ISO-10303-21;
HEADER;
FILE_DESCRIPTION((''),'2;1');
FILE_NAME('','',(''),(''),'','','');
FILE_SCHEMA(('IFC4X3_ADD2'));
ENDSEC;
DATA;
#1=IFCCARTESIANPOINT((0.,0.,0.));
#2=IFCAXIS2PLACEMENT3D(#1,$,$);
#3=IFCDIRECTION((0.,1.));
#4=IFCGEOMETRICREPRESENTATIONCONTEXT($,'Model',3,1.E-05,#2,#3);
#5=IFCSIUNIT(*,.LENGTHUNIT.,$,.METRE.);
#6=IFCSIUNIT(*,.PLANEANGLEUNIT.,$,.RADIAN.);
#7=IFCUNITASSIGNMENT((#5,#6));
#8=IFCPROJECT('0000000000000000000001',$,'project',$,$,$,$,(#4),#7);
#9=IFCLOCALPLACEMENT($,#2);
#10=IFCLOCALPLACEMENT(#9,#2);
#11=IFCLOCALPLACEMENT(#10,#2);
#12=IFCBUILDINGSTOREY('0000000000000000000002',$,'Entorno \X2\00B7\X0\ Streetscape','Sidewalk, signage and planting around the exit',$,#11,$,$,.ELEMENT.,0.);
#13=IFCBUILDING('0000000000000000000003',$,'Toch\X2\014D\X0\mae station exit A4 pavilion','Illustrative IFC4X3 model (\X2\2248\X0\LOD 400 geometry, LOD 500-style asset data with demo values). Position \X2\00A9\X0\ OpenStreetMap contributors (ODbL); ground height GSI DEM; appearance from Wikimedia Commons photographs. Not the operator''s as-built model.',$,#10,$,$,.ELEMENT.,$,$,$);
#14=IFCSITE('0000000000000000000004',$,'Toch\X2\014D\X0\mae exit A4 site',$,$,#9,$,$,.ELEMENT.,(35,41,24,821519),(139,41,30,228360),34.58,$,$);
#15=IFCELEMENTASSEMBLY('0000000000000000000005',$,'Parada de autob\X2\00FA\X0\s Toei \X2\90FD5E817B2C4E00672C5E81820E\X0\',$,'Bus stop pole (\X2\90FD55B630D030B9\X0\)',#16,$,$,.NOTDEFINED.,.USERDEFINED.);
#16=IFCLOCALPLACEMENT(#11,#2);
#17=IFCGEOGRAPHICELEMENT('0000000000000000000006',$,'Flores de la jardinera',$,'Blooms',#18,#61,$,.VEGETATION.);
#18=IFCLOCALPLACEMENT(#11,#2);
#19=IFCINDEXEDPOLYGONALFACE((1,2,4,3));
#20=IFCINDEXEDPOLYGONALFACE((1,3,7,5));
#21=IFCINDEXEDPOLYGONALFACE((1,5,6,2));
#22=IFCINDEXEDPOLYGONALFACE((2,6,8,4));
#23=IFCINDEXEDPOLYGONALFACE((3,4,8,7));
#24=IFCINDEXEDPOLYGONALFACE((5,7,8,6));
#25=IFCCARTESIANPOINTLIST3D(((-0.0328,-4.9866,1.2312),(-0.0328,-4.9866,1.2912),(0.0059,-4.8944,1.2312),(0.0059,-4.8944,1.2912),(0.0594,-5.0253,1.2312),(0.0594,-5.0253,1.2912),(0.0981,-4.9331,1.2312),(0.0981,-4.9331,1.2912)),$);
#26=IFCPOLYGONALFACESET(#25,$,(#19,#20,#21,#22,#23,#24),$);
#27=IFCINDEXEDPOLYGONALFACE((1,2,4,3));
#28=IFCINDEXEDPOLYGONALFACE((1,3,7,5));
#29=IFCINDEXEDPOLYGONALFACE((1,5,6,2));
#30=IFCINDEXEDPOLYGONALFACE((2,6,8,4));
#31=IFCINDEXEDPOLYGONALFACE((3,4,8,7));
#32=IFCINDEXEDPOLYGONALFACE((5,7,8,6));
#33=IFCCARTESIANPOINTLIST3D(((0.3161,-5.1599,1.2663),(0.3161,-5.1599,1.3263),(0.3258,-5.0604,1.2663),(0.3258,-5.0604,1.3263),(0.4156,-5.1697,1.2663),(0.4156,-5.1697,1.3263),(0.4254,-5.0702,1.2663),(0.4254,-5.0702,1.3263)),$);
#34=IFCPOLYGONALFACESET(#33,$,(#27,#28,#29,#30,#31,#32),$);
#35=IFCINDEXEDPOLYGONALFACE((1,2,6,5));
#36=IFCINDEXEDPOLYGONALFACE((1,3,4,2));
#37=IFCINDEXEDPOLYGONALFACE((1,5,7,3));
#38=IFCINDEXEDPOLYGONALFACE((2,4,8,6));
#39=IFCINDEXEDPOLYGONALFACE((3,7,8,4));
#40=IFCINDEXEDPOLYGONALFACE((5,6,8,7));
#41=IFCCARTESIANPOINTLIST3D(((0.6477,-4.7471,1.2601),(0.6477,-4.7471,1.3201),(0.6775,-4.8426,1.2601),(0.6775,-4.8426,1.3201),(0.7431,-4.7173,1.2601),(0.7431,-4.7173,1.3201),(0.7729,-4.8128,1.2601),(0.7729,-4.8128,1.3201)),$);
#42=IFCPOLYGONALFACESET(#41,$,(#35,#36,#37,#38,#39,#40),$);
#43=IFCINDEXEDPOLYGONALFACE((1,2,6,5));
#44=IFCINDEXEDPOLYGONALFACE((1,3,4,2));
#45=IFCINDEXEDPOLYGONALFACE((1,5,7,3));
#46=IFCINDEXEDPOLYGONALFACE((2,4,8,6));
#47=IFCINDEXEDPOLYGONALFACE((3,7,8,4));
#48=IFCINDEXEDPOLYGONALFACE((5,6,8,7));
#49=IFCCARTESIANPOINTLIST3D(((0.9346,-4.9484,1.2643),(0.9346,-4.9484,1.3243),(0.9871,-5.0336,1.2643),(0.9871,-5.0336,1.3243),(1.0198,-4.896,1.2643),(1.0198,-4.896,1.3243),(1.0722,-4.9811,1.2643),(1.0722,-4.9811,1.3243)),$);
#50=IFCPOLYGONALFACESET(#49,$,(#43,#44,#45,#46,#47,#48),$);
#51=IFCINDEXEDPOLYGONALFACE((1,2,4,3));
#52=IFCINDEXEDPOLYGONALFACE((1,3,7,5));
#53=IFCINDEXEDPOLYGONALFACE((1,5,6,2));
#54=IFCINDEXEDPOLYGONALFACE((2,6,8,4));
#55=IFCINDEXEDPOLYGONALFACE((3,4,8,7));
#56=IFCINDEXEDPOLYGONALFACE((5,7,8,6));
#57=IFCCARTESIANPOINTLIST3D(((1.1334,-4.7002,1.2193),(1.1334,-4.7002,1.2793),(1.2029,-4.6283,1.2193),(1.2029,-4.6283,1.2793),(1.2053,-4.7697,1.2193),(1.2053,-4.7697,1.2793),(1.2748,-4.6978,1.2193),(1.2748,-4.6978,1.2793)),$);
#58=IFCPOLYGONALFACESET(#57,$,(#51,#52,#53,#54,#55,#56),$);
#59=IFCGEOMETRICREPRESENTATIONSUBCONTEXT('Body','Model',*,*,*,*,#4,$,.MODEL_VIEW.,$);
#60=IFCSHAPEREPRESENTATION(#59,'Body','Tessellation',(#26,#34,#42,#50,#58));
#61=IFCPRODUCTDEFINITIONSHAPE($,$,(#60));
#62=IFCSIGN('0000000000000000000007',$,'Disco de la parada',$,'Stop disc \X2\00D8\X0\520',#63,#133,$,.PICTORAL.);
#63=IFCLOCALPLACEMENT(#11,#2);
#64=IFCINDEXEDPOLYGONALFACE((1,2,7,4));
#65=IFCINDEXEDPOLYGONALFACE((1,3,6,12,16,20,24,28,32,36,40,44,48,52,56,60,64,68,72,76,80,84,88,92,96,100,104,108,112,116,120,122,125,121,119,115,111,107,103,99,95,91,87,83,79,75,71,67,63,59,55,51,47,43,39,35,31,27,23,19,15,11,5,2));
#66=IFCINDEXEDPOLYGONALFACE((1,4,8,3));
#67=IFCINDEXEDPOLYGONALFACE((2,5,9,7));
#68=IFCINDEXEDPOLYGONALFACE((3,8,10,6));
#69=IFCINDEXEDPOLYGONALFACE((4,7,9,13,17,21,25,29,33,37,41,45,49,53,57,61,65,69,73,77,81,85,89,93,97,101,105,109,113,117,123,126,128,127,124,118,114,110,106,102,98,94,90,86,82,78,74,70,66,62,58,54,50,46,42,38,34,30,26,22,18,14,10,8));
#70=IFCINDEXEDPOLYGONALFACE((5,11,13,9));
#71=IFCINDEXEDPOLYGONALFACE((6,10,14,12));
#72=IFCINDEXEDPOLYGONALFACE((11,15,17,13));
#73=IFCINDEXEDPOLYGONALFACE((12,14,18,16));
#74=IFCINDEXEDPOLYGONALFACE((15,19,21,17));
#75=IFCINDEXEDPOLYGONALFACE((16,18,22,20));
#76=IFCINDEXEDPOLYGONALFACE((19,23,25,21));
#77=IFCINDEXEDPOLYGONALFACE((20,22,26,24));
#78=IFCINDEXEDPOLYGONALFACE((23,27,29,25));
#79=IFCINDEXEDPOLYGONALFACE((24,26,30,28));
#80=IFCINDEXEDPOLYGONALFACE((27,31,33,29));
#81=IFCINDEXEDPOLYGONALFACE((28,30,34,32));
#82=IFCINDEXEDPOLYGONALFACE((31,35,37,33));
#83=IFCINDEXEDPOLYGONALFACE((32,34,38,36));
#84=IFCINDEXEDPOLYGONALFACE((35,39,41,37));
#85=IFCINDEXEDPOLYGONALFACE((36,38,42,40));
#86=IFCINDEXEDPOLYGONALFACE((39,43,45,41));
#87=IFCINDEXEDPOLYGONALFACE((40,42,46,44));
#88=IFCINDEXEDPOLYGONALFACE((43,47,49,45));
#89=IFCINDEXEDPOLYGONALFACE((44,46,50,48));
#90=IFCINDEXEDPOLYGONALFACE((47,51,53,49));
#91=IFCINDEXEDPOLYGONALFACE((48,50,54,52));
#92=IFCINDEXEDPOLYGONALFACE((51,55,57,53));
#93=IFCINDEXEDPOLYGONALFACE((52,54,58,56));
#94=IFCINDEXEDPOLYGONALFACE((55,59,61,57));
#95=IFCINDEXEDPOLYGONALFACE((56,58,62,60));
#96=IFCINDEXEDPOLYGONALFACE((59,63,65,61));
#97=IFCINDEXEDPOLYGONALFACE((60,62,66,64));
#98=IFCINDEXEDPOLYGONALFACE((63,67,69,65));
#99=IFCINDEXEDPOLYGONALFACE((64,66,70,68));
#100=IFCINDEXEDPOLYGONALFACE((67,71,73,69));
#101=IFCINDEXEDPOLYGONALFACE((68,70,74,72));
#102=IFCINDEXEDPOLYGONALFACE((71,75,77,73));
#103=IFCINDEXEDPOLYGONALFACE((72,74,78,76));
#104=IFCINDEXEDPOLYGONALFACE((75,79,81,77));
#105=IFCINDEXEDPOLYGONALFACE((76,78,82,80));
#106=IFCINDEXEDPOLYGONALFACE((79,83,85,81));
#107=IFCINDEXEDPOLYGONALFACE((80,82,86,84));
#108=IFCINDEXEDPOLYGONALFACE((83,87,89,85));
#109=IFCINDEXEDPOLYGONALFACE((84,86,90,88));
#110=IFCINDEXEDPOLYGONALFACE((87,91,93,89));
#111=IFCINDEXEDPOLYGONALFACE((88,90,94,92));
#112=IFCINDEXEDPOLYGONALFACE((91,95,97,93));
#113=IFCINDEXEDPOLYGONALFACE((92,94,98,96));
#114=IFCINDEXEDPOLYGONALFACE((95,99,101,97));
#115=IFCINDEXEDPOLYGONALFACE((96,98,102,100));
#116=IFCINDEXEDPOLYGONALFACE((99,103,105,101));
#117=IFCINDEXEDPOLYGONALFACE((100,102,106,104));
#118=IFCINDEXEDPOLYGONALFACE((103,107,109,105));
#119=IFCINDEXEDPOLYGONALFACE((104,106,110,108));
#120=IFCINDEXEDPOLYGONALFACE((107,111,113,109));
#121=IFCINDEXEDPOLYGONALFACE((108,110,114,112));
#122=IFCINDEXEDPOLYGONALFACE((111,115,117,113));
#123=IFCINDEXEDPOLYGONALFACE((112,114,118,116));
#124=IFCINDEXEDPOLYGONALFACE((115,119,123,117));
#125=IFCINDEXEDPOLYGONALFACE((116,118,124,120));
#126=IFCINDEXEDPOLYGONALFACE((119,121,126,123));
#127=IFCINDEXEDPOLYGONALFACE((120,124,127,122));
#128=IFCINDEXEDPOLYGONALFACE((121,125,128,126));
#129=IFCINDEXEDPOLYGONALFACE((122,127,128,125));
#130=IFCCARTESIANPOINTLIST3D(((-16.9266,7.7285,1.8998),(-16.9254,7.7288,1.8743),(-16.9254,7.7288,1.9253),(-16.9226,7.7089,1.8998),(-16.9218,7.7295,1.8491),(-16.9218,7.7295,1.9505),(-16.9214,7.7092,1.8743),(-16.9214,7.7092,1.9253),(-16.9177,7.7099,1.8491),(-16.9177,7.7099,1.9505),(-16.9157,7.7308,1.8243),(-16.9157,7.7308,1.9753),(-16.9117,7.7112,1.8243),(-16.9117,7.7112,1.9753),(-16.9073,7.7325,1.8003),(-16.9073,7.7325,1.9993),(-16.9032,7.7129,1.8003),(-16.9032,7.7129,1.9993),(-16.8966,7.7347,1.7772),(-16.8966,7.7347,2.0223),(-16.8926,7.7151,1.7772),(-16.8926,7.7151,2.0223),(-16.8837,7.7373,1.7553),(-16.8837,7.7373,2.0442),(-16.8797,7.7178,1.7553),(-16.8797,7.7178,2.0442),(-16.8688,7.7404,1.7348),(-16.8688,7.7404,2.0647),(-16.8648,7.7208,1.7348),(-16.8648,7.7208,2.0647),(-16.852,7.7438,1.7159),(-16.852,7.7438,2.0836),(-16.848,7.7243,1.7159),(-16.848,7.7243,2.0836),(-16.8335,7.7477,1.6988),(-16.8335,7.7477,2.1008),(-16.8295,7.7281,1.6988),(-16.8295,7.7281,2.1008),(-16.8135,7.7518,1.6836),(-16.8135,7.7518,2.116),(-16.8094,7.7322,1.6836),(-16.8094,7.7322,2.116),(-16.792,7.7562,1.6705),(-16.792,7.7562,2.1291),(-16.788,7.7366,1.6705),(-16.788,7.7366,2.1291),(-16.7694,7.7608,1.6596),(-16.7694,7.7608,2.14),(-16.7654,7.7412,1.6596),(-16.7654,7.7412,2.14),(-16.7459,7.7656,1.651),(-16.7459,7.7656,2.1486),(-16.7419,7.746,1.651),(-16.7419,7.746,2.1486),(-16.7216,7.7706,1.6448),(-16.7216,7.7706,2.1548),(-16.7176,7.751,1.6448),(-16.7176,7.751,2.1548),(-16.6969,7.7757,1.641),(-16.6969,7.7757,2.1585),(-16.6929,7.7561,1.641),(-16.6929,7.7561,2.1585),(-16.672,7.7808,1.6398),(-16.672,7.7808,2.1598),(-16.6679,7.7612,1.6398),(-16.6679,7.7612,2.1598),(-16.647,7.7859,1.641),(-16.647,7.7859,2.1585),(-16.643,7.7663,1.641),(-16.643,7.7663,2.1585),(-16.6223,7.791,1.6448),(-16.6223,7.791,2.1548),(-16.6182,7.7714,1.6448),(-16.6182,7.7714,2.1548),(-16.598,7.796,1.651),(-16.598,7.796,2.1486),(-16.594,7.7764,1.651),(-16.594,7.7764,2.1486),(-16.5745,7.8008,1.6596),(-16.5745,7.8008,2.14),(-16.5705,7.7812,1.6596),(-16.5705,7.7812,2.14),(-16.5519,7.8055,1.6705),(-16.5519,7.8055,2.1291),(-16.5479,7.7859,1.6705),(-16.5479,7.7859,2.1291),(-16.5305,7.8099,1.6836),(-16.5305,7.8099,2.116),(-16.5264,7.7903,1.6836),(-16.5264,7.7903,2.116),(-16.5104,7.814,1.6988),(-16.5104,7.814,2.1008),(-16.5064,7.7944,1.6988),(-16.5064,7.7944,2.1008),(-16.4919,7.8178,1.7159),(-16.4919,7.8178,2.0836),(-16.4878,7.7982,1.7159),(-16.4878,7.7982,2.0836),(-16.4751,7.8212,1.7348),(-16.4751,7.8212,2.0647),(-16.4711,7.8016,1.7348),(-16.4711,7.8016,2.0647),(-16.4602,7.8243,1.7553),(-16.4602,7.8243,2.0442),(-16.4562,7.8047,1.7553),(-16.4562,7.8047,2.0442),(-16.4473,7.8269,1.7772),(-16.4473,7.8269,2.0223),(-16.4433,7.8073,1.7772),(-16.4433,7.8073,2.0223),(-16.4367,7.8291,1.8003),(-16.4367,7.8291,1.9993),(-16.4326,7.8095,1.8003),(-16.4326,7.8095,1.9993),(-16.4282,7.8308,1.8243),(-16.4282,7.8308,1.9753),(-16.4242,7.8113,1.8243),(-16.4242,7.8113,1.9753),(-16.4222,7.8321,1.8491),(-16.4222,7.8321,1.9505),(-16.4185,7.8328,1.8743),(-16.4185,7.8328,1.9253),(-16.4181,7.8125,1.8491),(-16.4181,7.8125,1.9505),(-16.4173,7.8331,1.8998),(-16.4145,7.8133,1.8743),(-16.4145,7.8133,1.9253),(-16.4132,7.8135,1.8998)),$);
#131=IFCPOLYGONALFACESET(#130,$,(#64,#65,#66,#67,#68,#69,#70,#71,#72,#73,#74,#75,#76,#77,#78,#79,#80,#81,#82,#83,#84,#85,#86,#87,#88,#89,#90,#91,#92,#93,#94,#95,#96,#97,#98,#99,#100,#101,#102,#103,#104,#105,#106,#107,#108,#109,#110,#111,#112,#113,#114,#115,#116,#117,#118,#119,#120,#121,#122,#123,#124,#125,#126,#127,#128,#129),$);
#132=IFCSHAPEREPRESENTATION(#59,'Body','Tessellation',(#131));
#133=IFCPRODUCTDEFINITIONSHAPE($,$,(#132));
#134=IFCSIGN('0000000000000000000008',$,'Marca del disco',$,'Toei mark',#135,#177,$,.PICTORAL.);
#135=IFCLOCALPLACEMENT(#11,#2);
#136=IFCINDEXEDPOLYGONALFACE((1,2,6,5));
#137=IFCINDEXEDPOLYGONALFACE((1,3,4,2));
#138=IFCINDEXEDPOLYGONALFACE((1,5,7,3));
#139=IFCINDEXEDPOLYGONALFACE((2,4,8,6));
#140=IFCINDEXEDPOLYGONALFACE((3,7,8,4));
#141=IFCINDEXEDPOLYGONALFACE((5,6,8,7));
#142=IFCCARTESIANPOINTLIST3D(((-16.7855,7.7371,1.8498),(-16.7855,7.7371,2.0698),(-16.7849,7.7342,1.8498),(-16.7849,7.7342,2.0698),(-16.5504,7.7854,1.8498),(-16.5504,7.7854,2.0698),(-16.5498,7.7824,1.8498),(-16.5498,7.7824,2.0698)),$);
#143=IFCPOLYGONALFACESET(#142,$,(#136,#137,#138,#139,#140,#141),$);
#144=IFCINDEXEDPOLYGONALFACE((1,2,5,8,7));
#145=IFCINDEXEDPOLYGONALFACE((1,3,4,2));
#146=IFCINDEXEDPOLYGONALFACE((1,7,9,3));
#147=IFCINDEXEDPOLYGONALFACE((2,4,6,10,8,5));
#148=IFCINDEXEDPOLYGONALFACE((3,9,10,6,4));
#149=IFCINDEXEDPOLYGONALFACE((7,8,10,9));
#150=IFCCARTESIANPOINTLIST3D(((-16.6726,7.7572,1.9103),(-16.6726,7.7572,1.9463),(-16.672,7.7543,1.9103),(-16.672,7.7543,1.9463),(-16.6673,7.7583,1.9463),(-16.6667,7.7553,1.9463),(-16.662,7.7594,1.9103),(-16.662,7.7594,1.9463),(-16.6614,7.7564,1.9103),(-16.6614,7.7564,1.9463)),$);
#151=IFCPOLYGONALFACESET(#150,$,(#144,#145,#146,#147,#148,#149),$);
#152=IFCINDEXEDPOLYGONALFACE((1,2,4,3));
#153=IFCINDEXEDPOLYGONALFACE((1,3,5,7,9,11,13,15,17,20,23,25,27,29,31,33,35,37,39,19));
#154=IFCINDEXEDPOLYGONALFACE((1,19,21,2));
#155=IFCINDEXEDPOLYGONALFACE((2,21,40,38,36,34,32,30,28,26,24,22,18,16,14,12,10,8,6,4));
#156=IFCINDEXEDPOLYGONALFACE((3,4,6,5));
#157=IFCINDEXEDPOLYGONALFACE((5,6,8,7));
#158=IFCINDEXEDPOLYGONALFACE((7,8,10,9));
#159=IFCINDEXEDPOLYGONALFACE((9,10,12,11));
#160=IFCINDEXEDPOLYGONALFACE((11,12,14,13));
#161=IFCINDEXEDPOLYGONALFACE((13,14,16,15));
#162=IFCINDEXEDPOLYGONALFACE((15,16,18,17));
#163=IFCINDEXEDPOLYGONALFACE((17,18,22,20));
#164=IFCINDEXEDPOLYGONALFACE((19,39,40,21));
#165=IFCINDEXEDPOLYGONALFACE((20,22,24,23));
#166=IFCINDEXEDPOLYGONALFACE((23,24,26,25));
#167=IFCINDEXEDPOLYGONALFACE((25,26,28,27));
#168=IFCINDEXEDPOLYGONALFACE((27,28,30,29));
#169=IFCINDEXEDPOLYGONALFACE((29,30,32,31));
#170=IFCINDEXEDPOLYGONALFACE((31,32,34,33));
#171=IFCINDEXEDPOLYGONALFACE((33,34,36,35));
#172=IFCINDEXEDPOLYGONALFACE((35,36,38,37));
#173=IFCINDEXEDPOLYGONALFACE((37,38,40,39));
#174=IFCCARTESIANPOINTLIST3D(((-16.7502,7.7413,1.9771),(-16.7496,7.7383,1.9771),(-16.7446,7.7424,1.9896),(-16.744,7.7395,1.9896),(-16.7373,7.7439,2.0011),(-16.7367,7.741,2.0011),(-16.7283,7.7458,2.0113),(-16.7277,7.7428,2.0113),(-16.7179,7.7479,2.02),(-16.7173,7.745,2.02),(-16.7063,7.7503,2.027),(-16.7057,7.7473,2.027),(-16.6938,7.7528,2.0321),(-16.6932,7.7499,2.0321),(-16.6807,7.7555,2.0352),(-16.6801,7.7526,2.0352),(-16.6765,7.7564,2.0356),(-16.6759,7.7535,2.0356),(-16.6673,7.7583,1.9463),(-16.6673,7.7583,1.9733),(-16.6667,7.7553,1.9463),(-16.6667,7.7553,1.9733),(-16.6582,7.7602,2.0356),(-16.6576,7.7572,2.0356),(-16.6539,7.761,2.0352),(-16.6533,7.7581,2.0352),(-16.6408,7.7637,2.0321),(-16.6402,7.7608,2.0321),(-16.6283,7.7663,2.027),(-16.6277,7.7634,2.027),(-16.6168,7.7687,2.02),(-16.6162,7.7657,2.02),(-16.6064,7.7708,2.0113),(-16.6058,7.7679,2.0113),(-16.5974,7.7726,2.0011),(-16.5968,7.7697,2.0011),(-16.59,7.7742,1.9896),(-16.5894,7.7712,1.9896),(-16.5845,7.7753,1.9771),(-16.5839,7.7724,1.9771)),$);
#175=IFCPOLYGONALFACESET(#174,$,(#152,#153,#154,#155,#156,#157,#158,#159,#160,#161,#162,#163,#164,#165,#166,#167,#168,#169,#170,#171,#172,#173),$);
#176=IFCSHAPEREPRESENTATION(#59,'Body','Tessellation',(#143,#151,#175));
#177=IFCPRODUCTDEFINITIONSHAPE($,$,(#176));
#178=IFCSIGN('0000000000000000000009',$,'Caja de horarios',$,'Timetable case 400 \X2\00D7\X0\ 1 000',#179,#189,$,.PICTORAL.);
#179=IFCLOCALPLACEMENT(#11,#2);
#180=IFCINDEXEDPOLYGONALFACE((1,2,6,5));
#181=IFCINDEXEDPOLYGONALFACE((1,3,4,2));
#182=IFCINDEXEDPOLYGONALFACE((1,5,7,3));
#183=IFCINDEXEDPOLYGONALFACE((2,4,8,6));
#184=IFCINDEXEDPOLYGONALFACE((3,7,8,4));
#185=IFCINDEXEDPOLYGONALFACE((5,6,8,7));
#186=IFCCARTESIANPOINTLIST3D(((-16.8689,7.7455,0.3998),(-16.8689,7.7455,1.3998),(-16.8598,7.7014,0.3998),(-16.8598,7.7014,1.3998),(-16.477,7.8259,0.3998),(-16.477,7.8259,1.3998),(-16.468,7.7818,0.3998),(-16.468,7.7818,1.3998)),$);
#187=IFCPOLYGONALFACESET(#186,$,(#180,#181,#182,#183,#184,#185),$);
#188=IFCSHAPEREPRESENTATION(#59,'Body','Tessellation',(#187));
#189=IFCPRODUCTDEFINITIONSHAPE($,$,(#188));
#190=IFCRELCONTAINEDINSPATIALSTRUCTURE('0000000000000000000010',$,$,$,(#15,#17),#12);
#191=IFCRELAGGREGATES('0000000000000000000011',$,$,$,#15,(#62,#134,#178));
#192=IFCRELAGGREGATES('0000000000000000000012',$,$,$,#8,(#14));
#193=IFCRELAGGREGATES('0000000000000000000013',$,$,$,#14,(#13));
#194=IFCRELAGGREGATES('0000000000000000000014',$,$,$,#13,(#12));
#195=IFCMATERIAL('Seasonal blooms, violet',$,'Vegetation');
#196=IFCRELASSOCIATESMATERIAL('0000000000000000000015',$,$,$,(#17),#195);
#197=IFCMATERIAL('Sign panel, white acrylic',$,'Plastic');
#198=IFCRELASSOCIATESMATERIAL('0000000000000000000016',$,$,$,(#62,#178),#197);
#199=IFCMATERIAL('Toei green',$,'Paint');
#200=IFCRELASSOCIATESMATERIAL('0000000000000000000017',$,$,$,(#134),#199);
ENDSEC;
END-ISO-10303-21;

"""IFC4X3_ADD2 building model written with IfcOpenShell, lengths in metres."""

from ifc_helpers import new_model, si_unit, direction, frame, frame_2d, origin, place, context, subcontext, project, spatial, polyline, rectangle, outline, extrude, material, element, aggregate, save


model = new_model("IFC4X3_ADD2")

# Units and contexts
model_context = context("Model", 3, precision=1e-05, world=origin(), true_north=direction((0.0, 1.0)))
body_context = subcontext(model_context, "Body", "Model", "MODEL_VIEW")
ifc_project = project(units=[si_unit("LENGTHUNIT", "METRE"), si_unit("PLANEANGLEUNIT", "RADIAN")], contexts=[model_context])

# Site, building, storey
site_placement = place(None, origin())
site = spatial("IfcSite", under=ifc_project, at=site_placement, Name="Tochōmae exit A4 site", CompositionType="ELEMENT", RefLatitude=(35, 41, 24, 821519), RefLongitude=(139, 41, 30, 228360), RefElevation=34.58)
building_placement = place(site_placement, origin())
building = spatial("IfcBuilding", under=site, at=building_placement, Name="Tochōmae station exit A4 pavilion", Description="Illustrative IFC4X3 model (≈LOD 400 geometry, LOD 500-style asset data with demo values). Position © OpenStreetMap contributors (ODbL); ground height GSI DEM; appearance from Wikimedia Commons photographs. Not the operator's as-built model.", CompositionType="ELEMENT")
storey_placement = place(building_placement, origin())
storey = spatial("IfcBuildingStorey", under=building, at=storey_placement, Name="Entorno · Streetscape", Description="Sidewalk, signage and planting around the exit", CompositionType="ELEMENT", Elevation=0.0)

# Element assembly
assembly_1_placement = place(building_placement, origin())
assembly_1 = element("IfcElementAssembly", 1, at=assembly_1_placement, inside=storey, Name="Parada de autobús Toei 都庁第一本庁舎", ObjectType="Bus stop pole (都営バス)", AssemblyPlace="NOTDEFINED", PredefinedType="USERDEFINED")

# Shared definitions
ifc_material_1 = material(Name="Sign panel, white acrylic", Category="Plastic")

# Geographic element
ifc_material_2 = material(Name="Seasonal blooms, violet", Category="Vegetation")
geographic_element_1_placement = place(building_placement, origin())
element("IfcGeographicElement", 2, at=geographic_element_1_placement, inside=storey, material=ifc_material_2, Name="Flores de la jardinera", ObjectType="Blooms", PredefinedType="VEGETATION", context=body_context, shape_type="SweptSolid", body=[
    extrude(rectangle(XDim=0.1, YDim=0.1, at=frame_2d((0.0, 0.0), x_axis=(0.922015, -0.387153))), frame((0.0326, -4.9599, 1.2312)), (0.0, 0.0, 1.0), 0.06),
    extrude(rectangle(XDim=0.1, YDim=0.1, at=frame_2d((0.0, 0.0), x_axis=(0.995247, -0.097387))), frame((0.3707, -5.1151, 1.2663)), (0.0, 0.0, 1.0), 0.06),
    extrude(rectangle(XDim=0.1, YDim=0.1, at=frame_2d((0.0, 0.0), x_axis=(0.954607, 0.297868))), frame((0.7103, -4.7799, 1.2601)), (0.0, 0.0, 1.0), 0.06),
    extrude(rectangle(XDim=0.1, YDim=0.1, at=frame_2d((0.0, 0.0), x_axis=(0.851237, 0.524781))), frame((1.0034, -4.9648, 1.2643)), (0.0, 0.0, 1.0), 0.06),
    extrude(rectangle(XDim=0.1, YDim=0.1, at=frame_2d((0.0, 0.0), x_axis=(0.694941, 0.719067))), frame((1.2041, -4.699, 1.2193)), (0.0, 0.0, 1.0), 0.06),
])

# Signs
sign_1_placement = place(building_placement, origin())
sign_1 = element("IfcSign", 3, at=sign_1_placement, material=ifc_material_1, Name="Disco de la parada", ObjectType="Stop disc Ø520", PredefinedType="PICTORAL", context=body_context, shape_type="SweptSolid", body=[
    extrude(outline(polyline([(0.26, 1.8998), (0.2587, 1.8743), (0.255, 1.8491), (0.2488, 1.8243), (0.2402, 1.8003), (0.2293, 1.7772), (0.2162, 1.7553), (0.201, 1.7348), (0.1838, 1.7159), (0.1649, 1.6988), (0.1444, 1.6836), (0.1226, 1.6705), (0.0995, 1.6596), (0.0755, 1.651), (0.0507, 1.6448), (0.0255, 1.641), (0.0, 1.6398), (-0.0255, 1.641), (-0.0507, 1.6448), (-0.0755, 1.651), (-0.0995, 1.6596), (-0.1226, 1.6705), (-0.1444, 1.6836), (-0.1649, 1.6988), (-0.1838, 1.7159), (-0.201, 1.7348), (-0.2162, 1.7553), (-0.2293, 1.7772), (-0.2402, 1.8003), (-0.2488, 1.8243), (-0.255, 1.8491), (-0.2587, 1.8743), (-0.26, 1.8998), (-0.2587, 1.9253), (-0.255, 1.9505), (-0.2488, 1.9753), (-0.2402, 1.9993), (-0.2293, 2.0223), (-0.2162, 2.0442), (-0.201, 2.0647), (-0.1838, 2.0836), (-0.1649, 2.1008), (-0.1444, 2.116), (-0.1226, 2.1291), (-0.0995, 2.14), (-0.0755, 2.1486), (-0.0507, 2.1548), (-0.0255, 2.1585), (0.0, 2.1598), (0.0255, 2.1585), (0.0507, 2.1548), (0.0755, 2.1486), (0.0995, 2.14), (0.1226, 2.1291), (0.1444, 2.116), (0.1649, 2.1008), (0.1838, 2.0836), (0.201, 2.0647), (0.2162, 2.0442), (0.2293, 2.0223), (0.2402, 1.9993), (0.2488, 1.9753), (0.255, 1.9505), (0.2587, 1.9253), (0.26, 1.8998)])), frame((-16.672, 7.7808, 0.0), z_axis=(0.201078, -0.979575, 0.0), x_axis=(0.979575, 0.201078, 0.0)), (0.0, 0.0, 1.0), 0.02),
])
ifc_material_3 = material(Name="Toei green", Category="Paint")
sign_2_placement = place(building_placement, origin())
sign_2 = element("IfcSign", 4, at=sign_2_placement, material=ifc_material_3, Name="Marca del disco", ObjectType="Toei mark", PredefinedType="PICTORAL", context=body_context, shape_type="SweptSolid", body=[
    extrude(outline(polyline([(-0.12, 1.8498), (0.12, 1.8498), (0.12, 2.0698), (-0.12, 2.0698), (-0.12, 1.8498)])), frame((-16.6679, 7.7612, 0.0), z_axis=(0.201078, -0.979575, 0.0), x_axis=(0.979575, 0.201078, 0.0)), (0.0, 0.0, 1.0), 0.003),
    extrude(outline(polyline([(0.0, 1.9463), (0.0054, 1.9463), (0.0054, 1.9103), (-0.0054, 1.9103), (-0.0054, 1.9463), (0.0, 1.9463)])), frame((-16.6673, 7.7583, 0.0), z_axis=(0.201078, -0.979575, 0.0), x_axis=(0.979575, 0.201078, 0.0)), (0.0, 0.0, 1.0), 0.003),
    extrude(outline(polyline([(-0.0789, 1.9896), (-0.0714, 2.0011), (-0.0622, 2.0113), (-0.0516, 2.02), (-0.0398, 2.027), (-0.0271, 2.0321), (-0.0137, 2.0352), (-0.0093, 2.0356), (0.0, 1.9733), (0.0093, 2.0356), (0.0137, 2.0352), (0.0271, 2.0321), (0.0398, 2.027), (0.0516, 2.02), (0.0622, 2.0113), (0.0714, 2.0011), (0.0789, 1.9896), (0.0846, 1.9771), (0.0, 1.9463), (-0.0846, 1.9771), (-0.0789, 1.9896)])), frame((-16.6673, 7.7583, 0.0), z_axis=(0.201078, -0.979575, 0.0), x_axis=(0.979575, 0.201078, 0.0)), (0.0, 0.0, 1.0), 0.003),
])
sign_3_placement = place(building_placement, origin())
sign_3 = element("IfcSign", 5, at=sign_3_placement, material=ifc_material_1, Name="Caja de horarios", ObjectType="Timetable case 400 × 1 000", PredefinedType="PICTORAL", context=body_context, shape_type="SweptSolid", body=[
    extrude(rectangle(XDim=0.4, YDim=0.045, at=frame_2d((0.0, 0.0), x_axis=(0.979575, 0.201078))), frame((-16.6684, 7.7637, 0.3998)), (0.0, 0.0, 1.0), 1.0),
])
aggregate(assembly_1, [sign_1, sign_2, sign_3])

save(model, "model.ifc")
